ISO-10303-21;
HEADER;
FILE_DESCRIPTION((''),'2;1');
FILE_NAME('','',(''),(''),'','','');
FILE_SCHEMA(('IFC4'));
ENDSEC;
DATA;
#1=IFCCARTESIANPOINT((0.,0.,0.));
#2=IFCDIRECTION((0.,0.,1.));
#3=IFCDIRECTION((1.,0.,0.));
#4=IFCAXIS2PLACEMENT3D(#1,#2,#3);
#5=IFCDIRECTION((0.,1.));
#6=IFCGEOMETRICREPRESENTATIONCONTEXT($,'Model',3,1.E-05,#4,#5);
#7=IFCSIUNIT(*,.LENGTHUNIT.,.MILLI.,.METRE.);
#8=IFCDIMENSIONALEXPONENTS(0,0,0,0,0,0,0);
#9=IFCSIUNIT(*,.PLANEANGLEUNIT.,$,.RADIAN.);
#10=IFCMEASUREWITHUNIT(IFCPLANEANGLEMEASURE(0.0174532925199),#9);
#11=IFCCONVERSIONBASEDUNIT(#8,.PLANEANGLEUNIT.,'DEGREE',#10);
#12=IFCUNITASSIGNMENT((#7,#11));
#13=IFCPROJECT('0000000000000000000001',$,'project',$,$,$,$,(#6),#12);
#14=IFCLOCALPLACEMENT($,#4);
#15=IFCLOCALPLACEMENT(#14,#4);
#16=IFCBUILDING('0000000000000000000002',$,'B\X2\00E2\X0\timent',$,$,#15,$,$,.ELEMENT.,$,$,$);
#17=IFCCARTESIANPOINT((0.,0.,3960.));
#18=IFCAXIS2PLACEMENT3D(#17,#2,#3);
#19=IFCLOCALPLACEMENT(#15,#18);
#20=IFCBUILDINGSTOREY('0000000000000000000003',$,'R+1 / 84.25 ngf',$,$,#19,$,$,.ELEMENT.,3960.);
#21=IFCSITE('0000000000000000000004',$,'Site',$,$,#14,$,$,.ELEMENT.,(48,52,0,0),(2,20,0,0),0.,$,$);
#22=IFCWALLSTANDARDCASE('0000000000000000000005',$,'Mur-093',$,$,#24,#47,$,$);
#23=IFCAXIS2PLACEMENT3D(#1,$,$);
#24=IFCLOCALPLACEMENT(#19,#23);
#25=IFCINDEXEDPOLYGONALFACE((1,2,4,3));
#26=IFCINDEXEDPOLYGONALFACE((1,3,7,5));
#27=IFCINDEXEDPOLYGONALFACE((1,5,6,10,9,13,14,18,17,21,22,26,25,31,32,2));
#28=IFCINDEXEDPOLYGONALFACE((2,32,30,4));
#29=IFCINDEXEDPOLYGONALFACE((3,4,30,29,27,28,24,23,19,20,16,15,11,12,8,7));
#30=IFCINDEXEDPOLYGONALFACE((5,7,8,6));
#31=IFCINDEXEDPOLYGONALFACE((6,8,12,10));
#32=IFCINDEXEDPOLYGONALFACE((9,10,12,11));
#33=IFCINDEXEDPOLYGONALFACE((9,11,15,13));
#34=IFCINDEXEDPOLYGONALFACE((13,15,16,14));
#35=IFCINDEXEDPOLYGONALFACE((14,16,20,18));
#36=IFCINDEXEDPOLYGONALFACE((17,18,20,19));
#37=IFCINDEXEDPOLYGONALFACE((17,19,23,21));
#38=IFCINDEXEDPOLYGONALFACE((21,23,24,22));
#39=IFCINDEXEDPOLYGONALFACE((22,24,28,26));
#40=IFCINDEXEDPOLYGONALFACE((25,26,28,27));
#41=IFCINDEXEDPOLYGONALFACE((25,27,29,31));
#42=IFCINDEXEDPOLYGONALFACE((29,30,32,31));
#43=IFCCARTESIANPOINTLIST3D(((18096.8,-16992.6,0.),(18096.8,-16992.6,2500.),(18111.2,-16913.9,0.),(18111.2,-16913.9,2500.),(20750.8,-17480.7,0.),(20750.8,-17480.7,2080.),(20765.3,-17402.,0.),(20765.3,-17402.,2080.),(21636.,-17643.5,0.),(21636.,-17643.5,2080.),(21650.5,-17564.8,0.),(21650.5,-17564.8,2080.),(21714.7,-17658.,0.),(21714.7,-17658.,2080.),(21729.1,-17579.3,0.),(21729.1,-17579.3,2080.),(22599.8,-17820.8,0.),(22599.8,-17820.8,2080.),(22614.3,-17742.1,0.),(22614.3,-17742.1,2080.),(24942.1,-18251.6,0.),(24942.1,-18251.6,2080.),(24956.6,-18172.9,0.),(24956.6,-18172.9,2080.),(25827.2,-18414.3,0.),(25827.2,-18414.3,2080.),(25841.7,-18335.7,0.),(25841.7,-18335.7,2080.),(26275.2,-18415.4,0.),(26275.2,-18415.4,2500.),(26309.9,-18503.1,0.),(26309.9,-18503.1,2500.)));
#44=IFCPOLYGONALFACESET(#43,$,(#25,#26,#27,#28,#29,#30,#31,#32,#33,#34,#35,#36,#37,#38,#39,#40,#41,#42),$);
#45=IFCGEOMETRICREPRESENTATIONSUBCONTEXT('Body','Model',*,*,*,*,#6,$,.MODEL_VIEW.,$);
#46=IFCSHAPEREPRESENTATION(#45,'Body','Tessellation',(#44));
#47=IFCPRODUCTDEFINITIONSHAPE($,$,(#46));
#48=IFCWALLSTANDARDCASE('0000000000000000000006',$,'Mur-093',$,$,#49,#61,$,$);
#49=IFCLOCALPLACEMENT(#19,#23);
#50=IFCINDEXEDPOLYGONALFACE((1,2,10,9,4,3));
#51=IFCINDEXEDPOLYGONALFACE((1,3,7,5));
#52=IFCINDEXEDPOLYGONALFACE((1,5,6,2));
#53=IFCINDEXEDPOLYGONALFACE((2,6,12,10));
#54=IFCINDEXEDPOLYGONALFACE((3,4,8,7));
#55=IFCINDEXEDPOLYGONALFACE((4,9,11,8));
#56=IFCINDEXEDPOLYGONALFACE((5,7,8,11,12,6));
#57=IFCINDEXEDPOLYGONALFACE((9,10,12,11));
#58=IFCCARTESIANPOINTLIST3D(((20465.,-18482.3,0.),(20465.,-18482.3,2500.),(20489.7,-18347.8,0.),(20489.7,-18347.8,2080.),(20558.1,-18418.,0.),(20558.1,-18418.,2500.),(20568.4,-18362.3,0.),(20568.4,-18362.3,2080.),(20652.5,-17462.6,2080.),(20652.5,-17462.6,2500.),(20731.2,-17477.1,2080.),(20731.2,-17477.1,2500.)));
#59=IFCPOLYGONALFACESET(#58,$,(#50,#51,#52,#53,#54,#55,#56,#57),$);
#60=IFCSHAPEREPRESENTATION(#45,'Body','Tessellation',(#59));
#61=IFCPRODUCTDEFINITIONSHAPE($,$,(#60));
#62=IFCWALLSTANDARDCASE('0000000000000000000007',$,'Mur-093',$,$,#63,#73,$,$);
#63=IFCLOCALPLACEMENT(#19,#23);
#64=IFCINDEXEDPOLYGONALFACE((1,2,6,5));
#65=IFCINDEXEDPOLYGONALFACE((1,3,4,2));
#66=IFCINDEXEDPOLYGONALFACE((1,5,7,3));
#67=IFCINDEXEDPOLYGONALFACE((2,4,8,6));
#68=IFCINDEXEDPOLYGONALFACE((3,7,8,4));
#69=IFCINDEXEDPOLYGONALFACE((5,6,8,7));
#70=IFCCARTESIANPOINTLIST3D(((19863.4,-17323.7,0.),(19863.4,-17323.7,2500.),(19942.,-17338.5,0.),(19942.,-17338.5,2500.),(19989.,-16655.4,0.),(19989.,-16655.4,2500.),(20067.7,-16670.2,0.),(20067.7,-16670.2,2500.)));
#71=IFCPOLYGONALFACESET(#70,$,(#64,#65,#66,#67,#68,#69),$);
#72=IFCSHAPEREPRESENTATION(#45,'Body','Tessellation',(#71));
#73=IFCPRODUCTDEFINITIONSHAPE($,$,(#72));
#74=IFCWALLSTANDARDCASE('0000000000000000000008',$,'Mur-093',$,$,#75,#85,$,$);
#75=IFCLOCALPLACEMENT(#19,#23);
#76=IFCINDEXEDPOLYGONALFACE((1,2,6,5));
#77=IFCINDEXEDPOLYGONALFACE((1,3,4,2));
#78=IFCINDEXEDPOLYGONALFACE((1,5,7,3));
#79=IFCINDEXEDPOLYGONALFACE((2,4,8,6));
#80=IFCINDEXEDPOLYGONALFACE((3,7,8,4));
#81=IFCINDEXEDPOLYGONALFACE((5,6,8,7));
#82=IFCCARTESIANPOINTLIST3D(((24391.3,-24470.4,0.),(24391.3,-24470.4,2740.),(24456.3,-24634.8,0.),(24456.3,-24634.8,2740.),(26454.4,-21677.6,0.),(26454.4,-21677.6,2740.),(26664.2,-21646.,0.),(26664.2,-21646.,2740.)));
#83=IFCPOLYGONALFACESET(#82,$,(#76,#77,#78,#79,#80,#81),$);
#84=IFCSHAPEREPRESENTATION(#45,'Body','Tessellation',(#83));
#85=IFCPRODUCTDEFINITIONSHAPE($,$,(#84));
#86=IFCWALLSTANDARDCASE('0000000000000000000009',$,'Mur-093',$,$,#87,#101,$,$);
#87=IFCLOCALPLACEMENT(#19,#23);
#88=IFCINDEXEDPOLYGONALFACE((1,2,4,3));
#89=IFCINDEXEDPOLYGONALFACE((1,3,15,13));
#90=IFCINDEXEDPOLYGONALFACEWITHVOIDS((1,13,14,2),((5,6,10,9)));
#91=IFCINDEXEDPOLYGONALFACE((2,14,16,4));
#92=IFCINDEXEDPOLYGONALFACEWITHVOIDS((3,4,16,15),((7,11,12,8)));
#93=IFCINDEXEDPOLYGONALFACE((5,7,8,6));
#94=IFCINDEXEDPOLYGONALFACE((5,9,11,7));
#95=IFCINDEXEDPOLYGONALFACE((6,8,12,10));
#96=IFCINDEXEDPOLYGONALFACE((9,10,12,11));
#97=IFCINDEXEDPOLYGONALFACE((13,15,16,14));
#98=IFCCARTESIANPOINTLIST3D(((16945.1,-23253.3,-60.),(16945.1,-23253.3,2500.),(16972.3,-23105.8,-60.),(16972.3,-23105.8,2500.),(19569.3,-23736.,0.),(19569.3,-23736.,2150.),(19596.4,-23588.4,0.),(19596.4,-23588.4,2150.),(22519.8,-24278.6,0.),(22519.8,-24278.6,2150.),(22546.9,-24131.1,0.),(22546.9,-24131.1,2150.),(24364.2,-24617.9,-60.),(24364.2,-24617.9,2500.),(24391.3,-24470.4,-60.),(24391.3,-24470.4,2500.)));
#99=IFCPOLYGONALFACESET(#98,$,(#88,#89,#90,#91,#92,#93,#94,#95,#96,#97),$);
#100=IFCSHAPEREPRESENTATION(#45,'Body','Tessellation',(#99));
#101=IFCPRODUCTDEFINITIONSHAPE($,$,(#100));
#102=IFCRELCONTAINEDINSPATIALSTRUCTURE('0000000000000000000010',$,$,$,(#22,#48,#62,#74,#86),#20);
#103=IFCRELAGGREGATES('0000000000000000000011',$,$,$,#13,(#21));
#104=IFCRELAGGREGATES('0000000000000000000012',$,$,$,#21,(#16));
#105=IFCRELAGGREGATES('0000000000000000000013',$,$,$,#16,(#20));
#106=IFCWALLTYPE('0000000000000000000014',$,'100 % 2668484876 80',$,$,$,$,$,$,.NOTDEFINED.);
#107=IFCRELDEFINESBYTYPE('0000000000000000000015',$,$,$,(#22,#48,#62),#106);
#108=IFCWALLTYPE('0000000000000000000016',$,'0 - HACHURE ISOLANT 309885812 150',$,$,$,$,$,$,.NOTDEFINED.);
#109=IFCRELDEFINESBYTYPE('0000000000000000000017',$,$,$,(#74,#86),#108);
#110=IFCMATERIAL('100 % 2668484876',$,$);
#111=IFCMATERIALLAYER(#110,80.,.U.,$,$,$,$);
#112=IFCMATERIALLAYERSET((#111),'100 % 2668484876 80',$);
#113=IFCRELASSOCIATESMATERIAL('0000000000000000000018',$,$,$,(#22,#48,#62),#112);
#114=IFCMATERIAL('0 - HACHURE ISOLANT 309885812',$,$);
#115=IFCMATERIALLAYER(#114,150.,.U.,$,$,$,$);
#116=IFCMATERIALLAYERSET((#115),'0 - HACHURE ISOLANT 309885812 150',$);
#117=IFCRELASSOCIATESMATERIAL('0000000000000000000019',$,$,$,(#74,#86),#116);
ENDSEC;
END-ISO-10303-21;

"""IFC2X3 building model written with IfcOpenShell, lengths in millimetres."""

from ifc_helpers import new_model, entity, si_unit, converted_unit, direction, frame, origin_with_axes, origin_2d_with_axis, place, context, subcontext, project, spatial, polyline, rectangle, outline, extrude, material, layer, layer_set, layer_usage, type_object, element, save


model = new_model("IFC2X3")

# Units and contexts
model_context = context("Model", 3, precision=1e-05, world=origin_with_axes(), true_north=direction((0.0, 1.0)))
body_context = subcontext(model_context, "Body", "Model", "MODEL_VIEW")
ifc_project = project(units=[si_unit("LENGTHUNIT", "METRE", prefix="MILLI"), converted_unit("PLANEANGLEUNIT", "DEGREE", entity("IfcPlaneAngleMeasure", 0.0174532925199), si_unit("PLANEANGLEUNIT", "RADIAN"), dimensions=[0, 0, 0, 0, 0, 0, 0])], contexts=[model_context])

# Site, building, storey
site_placement = place(None, origin_with_axes())
site = spatial("IfcSite", under=ifc_project, at=site_placement, Name="Site", CompositionType="ELEMENT", RefLatitude=(48, 52, 0, 0), RefLongitude=(2, 20, 0, 0), RefElevation=0.0)
building_placement = place(site_placement, origin_with_axes())
building = spatial("IfcBuilding", under=site, at=building_placement, Name="Bâtiment", CompositionType="ELEMENT")
storey_placement = place(building_placement, frame((0.0, 0.0, 3960.0), z_axis=(0.0, 0.0, 1.0), x_axis=(1.0, 0.0, 0.0)))
storey = spatial("IfcBuildingStorey", under=building, at=storey_placement, Name="R+1 / 84.25 ngf", CompositionType="ELEMENT", Elevation=3960.0)

# Shared definitions
ifc_material_1 = material(Name="100 % 2668484876")
ifc_layer_1 = layer(ifc_material_1, 80.0, ventilated="UNKNOWN")
ifc_layer_set_1 = layer_set([ifc_layer_1], Name="100 % 2668484876 80")
wall_type_1 = type_object("IfcWallType", Name="100 % 2668484876 80", PredefinedType="NOTDEFINED")

# Wall, openings
ifc_layer_usage_1 = layer_usage(ifc_layer_set_1, "AXIS2", "NEGATIVE", 80.0)
wall_1_placement = place(storey_placement, frame((18096.8, -16992.6, 0.0), z_axis=(0.0, 0.0, 1.0), x_axis=(0.983505, -0.180879, 0.0)))
wall_1 = element("IfcWallStandardCase", 1, at=wall_1_placement, inside=storey, type_object=wall_type_1, material=ifc_layer_usage_1, Name="Mur-093", context=body_context, shape_type="SweptSolid", body=[
    extrude(outline(polyline([(0.0, 0.0), (8350.9, 0.0), (8300.9, 80.0), (0.0, 80.0), (0.0, 0.0)])), origin_with_axes(), (0.0, 0.0, 1.0), 2500.0),
])
opening_1_placement = place(wall_1_placement, frame((7410.1, 0.0, 0.0), z_axis=(0.0, 0.0, 1.0), x_axis=(1.0, 0.0, 0.0)))
element("IfcOpeningElement", 2, at=opening_1_placement, cuts=wall_1, context=body_context, shape_type="SweptSolid", body=[
    extrude(rectangle(XDim=900.0, YDim=2080.0, at=origin_2d_with_axis()), frame((0.0, -80.0, 1040.0), z_axis=(0.0, -1.0, 0.0), x_axis=(1.0, 0.0, 0.0)), (0.0, 0.0, -1.0), 240.0),
])
opening_2_placement = place(wall_1_placement, frame((4128.6, 0.0, 0.0), z_axis=(0.0, 0.0, 1.0), x_axis=(1.0, 0.0, 0.0)))
element("IfcOpeningElement", 3, at=opening_2_placement, cuts=wall_1, context=body_context, shape_type="SweptSolid", body=[
    extrude(rectangle(XDim=900.0, YDim=2080.0, at=origin_2d_with_axis()), frame((0.0, -80.0, 1040.0), z_axis=(0.0, -1.0, 0.0), x_axis=(1.0, 0.0, 0.0)), (0.0, 0.0, -1.0), 240.0),
])
opening_3_placement = place(wall_1_placement, frame((3148.6, 0.0, 0.0), z_axis=(0.0, 0.0, 1.0), x_axis=(1.0, 0.0, 0.0)))
element("IfcOpeningElement", 4, at=opening_3_placement, cuts=wall_1, context=body_context, shape_type="SweptSolid", body=[
    extrude(rectangle(XDim=900.0, YDim=2080.0, at=origin_2d_with_axis()), frame((0.0, 160.0, 1040.0), z_axis=(0.0, -1.0, 0.0), x_axis=(1.0, 0.0, 0.0)), (0.0, 0.0, 1.0), 240.0),
])

# Wall, opening
ifc_layer_usage_2 = layer_usage(ifc_layer_set_1, "AXIS2", "POSITIVE", -80.0)
wall_2_placement = place(storey_placement, frame((20731.2, -17477.1, 0.0), z_axis=(0.0, 0.0, 1.0), x_axis=(-0.180879, -0.983505, 0.0)))
wall_2 = element("IfcWallStandardCase", 5, at=wall_2_placement, inside=storey, type_object=wall_type_1, material=ifc_layer_usage_2, Name="Mur-093", context=body_context, shape_type="SweptSolid", body=[
    extrude(outline(polyline([(0.0, -80.0), (1036.7, -80.0), (956.7, 0.0), (0.0, 0.0), (0.0, -80.0)])), origin_with_axes(), (0.0, 0.0, 1.0), 2500.0),
])
opening_4_placement = place(wall_2_placement, frame((450.0, 0.0, 0.0), z_axis=(0.0, 0.0, 1.0), x_axis=(1.0, 0.0, 0.0)))
element("IfcOpeningElement", 6, at=opening_4_placement, cuts=wall_2, context=body_context, shape_type="SweptSolid", body=[
    extrude(rectangle(XDim=900.0, YDim=2080.0, at=origin_2d_with_axis()), frame((0.0, 80.0, 1040.0), z_axis=(0.0, 1.0, 0.0), x_axis=(-1.0, 0.0, 0.0)), (0.0, 0.0, -1.0), 240.0),
])

# Walls
ifc_layer_usage_3 = layer_usage(ifc_layer_set_1, "AXIS2", "POSITIVE", -80.0)
wall_3_placement = place(storey_placement, frame((19863.4, -17323.7, 0.0), z_axis=(0.0, 0.0, 1.0), x_axis=(0.18472, 0.982791, 0.0)))
element("IfcWallStandardCase", 7, at=wall_3_placement, inside=storey, type_object=wall_type_1, material=ifc_layer_usage_3, Name="Mur-093", context=body_context, shape_type="SweptSolid", body=[
    extrude(outline(polyline([(0.0, -80.0), (680.0, -80.0), (680.0, 0.0), (0.0, 0.0), (0.0, -80.0)])), origin_with_axes(), (0.0, 0.0, 1.0), 2500.0),
])
ifc_material_2 = material(Name="0 - HACHURE ISOLANT 309885812")
ifc_layer_2 = layer(ifc_material_2, 150.0, ventilated="UNKNOWN")
ifc_layer_set_2 = layer_set([ifc_layer_2], Name="0 - HACHURE ISOLANT 309885812 150")
ifc_layer_usage_4 = layer_usage(ifc_layer_set_2, "AXIS2", "POSITIVE", -150.0)
wall_type_2 = type_object("IfcWallType", Name="0 - HACHURE ISOLANT 309885812 150", PredefinedType="NOTDEFINED")
wall_4_placement = place(storey_placement, frame((24391.3, -24470.4, 0.0), z_axis=(0.0, 0.0, 1.0), x_axis=(0.594173, 0.804337, 0.0)))
element("IfcWallStandardCase", 8, at=wall_4_placement, inside=storey, type_object=wall_type_2, material=ifc_layer_usage_4, Name="Mur-093", context=body_context, shape_type="SweptSolid", body=[
    extrude(outline(polyline([(-93.7, -150.0), (3622.3, -150.0), (3472.1, 0.0), (0.0, 0.0), (-93.7, -150.0)])), origin_with_axes(), (0.0, 0.0, 1.0), 2740.0),
])

# Wall, opening
ifc_layer_usage_5 = layer_usage(ifc_layer_set_2, "AXIS2", "NEGATIVE", 150.0)
wall_5_placement = place(storey_placement, frame((24391.3, -24470.4, -60.0), z_axis=(0.0, 0.0, 1.0), x_axis=(-0.983503, 0.180891, 0.0)))
wall_5 = element("IfcWallStandardCase", 9, at=wall_5_placement, inside=storey, type_object=wall_type_2, material=ifc_layer_usage_5, Name="Mur-093", context=body_context, shape_type="SweptSolid", body=[
    extrude(outline(polyline([(0.0, 0.0), (7543.5, 0.0), (7543.5, 150.0), (0.0, 150.0), (0.0, 0.0)])), origin_with_axes(), (0.0, 0.0, 1.0), 2560.0),
])
opening_5_placement = place(wall_5_placement, frame((3375.4, 0.0, 60.0), z_axis=(0.0, 0.0, 1.0), x_axis=(1.0, 0.0, 0.0)))
element("IfcOpeningElement", 10, at=opening_5_placement, cuts=wall_5, context=body_context, shape_type="SweptSolid", body=[
    extrude(rectangle(XDim=3000.0, YDim=2150.0, at=origin_2d_with_axis()), frame((0.0, -150.0, 1075.0), z_axis=(0.0, -1.0, 0.0), x_axis=(1.0, 0.0, 0.0)), (0.0, 0.0, -1.0), 450.0),
])

save(model, "model.ifc")
